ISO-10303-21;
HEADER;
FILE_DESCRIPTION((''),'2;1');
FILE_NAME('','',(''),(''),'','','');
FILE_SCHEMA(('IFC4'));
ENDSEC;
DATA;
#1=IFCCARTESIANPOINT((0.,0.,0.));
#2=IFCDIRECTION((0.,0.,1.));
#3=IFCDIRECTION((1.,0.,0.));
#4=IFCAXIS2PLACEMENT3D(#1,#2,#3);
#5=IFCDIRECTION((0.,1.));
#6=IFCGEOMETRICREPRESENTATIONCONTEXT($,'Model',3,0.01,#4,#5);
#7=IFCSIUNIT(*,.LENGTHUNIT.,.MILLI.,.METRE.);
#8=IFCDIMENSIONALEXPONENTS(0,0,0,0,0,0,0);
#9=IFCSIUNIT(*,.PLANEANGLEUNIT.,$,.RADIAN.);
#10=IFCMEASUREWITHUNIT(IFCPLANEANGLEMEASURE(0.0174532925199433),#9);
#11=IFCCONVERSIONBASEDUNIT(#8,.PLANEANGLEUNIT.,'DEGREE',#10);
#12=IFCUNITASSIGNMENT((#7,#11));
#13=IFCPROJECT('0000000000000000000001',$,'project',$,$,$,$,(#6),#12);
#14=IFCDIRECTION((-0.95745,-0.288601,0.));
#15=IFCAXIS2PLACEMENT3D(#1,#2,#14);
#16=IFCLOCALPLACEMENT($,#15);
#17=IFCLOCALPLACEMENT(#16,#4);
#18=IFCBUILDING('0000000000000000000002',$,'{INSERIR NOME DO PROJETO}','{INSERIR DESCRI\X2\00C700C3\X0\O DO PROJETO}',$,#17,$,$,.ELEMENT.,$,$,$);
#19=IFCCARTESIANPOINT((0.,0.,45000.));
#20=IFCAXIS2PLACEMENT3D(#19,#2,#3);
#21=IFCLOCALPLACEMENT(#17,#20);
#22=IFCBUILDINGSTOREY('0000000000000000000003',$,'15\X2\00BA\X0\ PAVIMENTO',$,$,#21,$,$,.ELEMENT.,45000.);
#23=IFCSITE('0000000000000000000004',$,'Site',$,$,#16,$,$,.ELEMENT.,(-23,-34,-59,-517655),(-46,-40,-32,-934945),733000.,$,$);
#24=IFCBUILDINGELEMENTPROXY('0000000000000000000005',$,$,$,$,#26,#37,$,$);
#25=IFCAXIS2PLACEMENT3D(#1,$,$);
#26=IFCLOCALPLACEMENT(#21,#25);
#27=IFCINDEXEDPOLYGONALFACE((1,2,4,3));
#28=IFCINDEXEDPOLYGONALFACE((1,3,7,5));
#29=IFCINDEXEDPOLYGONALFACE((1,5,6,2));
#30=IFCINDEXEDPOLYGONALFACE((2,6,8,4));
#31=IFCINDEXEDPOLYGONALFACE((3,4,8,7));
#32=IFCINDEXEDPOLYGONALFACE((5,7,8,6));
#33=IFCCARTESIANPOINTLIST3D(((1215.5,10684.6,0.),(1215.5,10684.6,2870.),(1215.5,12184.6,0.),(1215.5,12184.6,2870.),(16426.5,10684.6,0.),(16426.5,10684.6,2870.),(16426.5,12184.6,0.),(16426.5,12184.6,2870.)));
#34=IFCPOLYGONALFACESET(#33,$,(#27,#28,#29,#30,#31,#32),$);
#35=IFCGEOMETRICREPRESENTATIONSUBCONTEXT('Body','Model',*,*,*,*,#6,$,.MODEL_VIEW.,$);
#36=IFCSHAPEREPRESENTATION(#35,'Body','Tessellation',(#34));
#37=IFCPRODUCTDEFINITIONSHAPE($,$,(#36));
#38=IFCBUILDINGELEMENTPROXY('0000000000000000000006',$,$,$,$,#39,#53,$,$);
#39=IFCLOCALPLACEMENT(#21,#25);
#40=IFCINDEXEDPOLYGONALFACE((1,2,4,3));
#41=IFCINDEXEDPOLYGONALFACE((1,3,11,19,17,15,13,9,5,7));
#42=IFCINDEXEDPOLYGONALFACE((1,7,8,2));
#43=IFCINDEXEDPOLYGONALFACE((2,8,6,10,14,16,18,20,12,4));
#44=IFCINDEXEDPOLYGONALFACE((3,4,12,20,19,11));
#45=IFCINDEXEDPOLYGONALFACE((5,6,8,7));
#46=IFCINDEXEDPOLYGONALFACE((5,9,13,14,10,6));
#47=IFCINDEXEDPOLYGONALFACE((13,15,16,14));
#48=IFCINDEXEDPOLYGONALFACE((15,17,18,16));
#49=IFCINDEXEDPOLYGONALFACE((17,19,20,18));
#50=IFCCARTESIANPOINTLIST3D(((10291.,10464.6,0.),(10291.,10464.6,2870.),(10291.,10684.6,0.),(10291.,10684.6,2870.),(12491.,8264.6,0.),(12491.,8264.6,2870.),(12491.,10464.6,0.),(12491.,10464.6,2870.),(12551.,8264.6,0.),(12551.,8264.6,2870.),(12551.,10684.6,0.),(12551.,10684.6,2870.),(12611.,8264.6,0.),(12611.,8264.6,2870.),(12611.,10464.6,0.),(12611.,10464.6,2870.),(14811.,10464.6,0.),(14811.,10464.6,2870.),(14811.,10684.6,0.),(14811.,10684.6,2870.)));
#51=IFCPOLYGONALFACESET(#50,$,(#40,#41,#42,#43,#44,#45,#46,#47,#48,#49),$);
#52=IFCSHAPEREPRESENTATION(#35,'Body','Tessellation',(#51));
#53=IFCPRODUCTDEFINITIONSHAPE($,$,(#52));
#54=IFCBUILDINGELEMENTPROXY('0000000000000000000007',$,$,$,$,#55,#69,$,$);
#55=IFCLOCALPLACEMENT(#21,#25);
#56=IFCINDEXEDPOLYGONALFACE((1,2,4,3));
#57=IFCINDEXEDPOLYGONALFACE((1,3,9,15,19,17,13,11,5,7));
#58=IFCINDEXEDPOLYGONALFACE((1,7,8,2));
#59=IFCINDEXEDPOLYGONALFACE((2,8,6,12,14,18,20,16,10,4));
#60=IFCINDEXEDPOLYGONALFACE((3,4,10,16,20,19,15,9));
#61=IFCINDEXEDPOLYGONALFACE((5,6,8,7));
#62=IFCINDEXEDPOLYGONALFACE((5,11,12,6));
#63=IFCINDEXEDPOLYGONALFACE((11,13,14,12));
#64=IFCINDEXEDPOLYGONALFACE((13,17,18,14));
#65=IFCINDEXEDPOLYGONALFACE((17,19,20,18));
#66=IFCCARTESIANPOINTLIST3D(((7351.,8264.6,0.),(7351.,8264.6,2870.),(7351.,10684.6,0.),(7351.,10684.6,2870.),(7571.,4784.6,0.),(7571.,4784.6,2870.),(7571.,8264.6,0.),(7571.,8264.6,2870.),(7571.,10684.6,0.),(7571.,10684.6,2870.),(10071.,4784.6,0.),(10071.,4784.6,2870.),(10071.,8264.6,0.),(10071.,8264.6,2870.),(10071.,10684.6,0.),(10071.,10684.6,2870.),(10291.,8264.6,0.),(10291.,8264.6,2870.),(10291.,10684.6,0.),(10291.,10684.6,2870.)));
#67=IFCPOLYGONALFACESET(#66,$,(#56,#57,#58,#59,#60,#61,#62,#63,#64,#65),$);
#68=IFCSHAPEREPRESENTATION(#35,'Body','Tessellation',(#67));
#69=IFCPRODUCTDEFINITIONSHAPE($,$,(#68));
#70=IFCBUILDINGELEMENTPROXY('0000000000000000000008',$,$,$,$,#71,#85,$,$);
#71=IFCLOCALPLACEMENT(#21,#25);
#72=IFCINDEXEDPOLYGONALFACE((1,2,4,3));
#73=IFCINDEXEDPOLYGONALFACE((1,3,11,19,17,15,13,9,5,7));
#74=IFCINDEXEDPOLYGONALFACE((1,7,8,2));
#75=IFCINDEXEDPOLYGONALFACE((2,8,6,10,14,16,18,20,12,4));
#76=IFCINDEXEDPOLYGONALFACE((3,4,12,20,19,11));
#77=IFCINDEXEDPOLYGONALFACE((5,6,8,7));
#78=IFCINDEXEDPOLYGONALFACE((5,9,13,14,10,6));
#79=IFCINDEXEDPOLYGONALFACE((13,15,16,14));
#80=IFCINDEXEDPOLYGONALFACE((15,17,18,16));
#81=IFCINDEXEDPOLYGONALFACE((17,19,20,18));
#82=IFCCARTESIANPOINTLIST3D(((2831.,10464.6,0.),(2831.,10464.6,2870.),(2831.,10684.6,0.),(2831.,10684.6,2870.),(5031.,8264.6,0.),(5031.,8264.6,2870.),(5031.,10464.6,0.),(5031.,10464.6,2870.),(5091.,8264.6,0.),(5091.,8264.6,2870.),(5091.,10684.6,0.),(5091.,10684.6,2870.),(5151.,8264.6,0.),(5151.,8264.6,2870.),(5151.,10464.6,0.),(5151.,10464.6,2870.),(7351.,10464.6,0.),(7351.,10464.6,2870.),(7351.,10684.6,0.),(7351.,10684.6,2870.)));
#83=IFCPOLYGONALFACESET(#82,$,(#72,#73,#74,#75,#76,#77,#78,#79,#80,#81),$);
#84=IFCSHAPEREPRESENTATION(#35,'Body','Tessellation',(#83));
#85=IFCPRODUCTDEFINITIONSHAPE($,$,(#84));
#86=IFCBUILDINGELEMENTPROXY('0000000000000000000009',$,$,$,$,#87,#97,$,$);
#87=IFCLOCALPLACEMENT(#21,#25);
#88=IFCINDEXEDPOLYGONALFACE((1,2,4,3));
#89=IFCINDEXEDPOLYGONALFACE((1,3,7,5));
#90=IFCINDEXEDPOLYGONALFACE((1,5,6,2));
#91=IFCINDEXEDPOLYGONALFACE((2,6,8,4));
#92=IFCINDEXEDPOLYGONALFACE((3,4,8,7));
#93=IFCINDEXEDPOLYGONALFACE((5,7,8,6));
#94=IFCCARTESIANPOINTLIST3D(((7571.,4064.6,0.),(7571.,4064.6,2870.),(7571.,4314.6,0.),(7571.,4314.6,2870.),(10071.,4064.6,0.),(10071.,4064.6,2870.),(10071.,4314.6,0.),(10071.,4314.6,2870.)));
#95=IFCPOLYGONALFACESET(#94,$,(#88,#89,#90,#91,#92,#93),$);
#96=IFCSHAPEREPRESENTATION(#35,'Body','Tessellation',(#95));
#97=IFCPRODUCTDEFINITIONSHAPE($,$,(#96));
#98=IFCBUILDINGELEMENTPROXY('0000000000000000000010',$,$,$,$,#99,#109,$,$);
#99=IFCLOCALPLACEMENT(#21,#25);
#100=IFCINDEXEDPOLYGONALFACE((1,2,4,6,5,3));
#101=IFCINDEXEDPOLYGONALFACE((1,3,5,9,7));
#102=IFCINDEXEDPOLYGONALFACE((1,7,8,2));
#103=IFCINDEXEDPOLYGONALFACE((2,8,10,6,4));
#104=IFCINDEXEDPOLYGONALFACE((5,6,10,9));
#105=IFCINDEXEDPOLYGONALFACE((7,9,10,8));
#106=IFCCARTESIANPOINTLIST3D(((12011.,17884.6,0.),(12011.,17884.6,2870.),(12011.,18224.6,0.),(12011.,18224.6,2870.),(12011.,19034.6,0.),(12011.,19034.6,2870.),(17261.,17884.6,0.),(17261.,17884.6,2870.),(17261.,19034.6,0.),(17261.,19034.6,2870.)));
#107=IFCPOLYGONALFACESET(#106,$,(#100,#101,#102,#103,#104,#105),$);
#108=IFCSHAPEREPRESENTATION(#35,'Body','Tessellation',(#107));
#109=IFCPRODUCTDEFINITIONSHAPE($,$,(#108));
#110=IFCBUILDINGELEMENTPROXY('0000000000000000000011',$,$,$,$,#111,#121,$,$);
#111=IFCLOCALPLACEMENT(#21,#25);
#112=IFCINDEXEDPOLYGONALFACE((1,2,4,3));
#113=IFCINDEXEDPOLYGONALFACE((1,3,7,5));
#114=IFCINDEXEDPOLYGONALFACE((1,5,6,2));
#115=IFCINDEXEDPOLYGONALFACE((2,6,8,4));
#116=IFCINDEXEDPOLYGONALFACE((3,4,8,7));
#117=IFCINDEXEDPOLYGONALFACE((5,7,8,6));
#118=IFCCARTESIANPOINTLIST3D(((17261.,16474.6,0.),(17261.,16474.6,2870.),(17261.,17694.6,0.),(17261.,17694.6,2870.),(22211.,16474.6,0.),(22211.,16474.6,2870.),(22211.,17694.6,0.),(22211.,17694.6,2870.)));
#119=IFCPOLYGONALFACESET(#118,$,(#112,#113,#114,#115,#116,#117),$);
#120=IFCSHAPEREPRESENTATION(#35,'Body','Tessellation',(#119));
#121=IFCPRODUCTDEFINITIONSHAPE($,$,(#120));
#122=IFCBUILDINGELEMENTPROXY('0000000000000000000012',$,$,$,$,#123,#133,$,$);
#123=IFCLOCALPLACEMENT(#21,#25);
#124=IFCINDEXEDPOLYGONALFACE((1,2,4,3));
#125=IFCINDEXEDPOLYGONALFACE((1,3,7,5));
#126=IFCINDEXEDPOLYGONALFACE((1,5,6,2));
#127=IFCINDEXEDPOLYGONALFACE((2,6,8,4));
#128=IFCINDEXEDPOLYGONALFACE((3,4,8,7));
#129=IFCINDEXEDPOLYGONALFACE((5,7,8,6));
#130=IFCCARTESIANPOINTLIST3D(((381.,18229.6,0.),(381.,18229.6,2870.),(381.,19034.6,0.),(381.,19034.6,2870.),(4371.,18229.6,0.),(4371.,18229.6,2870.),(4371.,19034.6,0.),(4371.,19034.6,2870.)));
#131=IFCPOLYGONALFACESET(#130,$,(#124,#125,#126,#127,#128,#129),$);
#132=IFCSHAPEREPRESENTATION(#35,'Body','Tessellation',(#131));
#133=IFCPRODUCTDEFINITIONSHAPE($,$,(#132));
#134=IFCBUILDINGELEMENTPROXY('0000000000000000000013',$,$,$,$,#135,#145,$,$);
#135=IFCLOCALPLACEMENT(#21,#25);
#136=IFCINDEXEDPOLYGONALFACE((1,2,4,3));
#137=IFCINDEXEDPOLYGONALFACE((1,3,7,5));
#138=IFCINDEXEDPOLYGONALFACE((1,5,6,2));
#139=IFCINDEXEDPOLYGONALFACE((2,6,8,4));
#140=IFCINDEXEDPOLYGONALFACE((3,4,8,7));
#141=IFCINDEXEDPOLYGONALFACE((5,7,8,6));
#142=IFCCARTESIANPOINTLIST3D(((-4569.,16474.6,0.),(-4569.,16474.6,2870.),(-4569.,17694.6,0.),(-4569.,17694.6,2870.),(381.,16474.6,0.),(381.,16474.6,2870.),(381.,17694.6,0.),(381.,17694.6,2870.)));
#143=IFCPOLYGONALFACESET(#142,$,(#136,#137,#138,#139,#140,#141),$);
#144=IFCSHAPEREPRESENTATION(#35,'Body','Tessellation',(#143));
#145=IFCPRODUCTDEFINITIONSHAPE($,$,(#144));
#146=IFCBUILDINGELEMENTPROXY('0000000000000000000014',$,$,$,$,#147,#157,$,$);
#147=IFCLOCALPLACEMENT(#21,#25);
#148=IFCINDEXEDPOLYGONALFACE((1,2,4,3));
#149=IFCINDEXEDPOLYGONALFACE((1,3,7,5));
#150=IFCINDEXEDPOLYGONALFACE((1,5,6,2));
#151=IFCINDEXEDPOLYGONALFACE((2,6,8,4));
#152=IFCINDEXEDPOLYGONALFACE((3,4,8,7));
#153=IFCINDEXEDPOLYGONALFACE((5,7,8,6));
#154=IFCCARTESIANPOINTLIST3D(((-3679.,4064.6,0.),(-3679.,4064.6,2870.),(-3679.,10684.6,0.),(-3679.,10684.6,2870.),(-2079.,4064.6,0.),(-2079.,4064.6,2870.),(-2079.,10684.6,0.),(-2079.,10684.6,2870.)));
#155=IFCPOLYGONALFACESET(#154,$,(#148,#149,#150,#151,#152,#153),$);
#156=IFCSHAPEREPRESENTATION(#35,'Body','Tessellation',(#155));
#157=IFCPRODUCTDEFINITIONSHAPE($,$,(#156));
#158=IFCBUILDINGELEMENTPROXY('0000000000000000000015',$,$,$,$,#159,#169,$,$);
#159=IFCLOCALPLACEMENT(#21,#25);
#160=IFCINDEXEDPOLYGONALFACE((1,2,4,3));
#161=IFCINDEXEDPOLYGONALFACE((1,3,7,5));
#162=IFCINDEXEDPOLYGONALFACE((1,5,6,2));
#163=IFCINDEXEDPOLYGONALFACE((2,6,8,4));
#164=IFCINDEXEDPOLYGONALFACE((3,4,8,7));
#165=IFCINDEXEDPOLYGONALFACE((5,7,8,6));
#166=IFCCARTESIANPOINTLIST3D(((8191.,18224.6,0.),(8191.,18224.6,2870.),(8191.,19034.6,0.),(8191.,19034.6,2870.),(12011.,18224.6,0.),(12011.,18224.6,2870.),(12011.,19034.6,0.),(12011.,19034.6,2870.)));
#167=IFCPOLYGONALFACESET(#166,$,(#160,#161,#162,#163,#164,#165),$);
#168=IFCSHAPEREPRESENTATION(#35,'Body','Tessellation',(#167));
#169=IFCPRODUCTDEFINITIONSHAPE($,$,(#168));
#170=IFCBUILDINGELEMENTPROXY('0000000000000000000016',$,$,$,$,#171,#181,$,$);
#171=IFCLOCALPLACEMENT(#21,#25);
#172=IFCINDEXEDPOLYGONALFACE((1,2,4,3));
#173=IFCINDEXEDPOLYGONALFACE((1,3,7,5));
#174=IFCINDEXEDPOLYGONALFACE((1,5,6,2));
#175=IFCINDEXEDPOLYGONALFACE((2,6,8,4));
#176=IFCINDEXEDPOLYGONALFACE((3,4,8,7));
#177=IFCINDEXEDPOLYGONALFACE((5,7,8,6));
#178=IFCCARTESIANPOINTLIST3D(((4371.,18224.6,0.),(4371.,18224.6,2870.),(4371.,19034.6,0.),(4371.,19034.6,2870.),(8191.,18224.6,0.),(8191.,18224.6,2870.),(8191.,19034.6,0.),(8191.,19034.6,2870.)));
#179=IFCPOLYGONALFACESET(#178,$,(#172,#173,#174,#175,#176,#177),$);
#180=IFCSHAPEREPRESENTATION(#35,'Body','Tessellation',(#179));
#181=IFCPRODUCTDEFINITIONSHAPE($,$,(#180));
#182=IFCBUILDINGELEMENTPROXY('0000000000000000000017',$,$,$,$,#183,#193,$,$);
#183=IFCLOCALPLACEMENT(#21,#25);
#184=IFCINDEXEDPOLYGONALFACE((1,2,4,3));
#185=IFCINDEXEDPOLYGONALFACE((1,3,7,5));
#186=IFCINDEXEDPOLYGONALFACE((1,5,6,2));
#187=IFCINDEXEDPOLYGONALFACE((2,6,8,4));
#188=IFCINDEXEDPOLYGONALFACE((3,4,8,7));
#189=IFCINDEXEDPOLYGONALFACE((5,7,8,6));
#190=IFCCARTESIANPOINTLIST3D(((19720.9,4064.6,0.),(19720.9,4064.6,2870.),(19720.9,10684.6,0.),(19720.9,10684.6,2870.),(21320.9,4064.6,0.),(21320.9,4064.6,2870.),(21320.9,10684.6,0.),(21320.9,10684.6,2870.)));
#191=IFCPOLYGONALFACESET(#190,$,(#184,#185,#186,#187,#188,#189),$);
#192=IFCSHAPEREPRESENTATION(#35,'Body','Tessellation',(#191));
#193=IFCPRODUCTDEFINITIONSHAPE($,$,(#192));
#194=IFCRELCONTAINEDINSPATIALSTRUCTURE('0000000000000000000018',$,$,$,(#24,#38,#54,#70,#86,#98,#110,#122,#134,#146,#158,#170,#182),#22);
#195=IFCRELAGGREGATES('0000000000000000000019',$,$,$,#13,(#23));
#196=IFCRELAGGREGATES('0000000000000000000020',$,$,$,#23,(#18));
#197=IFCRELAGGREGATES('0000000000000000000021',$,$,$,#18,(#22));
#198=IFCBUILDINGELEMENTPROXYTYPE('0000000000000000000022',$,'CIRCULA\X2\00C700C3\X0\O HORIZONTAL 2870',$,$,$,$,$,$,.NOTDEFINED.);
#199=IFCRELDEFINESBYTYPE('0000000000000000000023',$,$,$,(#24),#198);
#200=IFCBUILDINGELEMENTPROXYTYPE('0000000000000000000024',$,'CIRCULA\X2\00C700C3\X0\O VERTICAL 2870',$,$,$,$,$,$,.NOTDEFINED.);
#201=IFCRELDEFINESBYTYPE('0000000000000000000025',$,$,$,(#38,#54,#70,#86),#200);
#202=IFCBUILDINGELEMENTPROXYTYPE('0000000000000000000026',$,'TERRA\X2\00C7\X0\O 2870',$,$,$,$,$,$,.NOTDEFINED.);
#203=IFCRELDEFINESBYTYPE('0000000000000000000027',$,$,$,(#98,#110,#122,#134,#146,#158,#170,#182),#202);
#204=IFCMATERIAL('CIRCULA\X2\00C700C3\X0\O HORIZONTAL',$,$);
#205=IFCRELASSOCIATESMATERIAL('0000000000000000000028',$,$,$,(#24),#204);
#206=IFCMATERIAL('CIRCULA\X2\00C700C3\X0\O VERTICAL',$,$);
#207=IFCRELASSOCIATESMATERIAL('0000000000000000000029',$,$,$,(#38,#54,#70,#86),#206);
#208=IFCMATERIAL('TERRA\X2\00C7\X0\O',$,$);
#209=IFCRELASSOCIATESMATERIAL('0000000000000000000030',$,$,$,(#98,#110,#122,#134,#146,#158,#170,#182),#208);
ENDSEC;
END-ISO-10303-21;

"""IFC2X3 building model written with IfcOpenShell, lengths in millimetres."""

from ifc_helpers import new_model, entity, si_unit, converted_unit, direction, frame, origin_with_axes, place, context, subcontext, project, spatial, polyline, outline, extrude, material, type_object, element, save


model = new_model("IFC2X3")

# Units and contexts
model_context = context("Model", 3, precision=0.01, world=origin_with_axes(), true_north=direction((0.0, 1.0)))
body_context = subcontext(model_context, "Body", "Model", "MODEL_VIEW")
ifc_project = project(units=[si_unit("LENGTHUNIT", "METRE", prefix="MILLI"), converted_unit("PLANEANGLEUNIT", "DEGREE", entity("IfcPlaneAngleMeasure", 0.0174532925199433), si_unit("PLANEANGLEUNIT", "RADIAN"), dimensions=[0, 0, 0, 0, 0, 0, 0])], contexts=[model_context])

# Site, building, storey
site_placement = place(None, frame((0.0, 0.0, 0.0), z_axis=(0.0, 0.0, 1.0), x_axis=(-0.95745, -0.288601, 0.0)))
site = spatial("IfcSite", under=ifc_project, at=site_placement, Name="Site", CompositionType="ELEMENT", RefLatitude=(-23, -34, -59, -517655), RefLongitude=(-46, -40, -32, -934945), RefElevation=733000.0)
building_placement = place(site_placement, origin_with_axes())
building = spatial("IfcBuilding", under=site, at=building_placement, Name="{INSERIR NOME DO PROJETO}", Description="{INSERIR DESCRIÇÃO DO PROJETO}", CompositionType="ELEMENT")
storey_placement = place(building_placement, frame((0.0, 0.0, 45000.0), z_axis=(0.0, 0.0, 1.0), x_axis=(1.0, 0.0, 0.0)))
storey = spatial("IfcBuildingStorey", under=building, at=storey_placement, Name="15º PAVIMENTO", CompositionType="ELEMENT", Elevation=45000.0)

# Building element proxies
ifc_material_1 = material(Name="CIRCULAÇÃO HORIZONTAL")
building_element_proxy_type_1 = type_object("IfcBuildingElementProxyType", Name="CIRCULAÇÃO HORIZONTAL 2870", PredefinedType="NOTDEFINED")
proxy_1_placement = place(storey_placement, frame((1215.5, 10684.6, 0.0), z_axis=(0.0, 0.0, 1.0), x_axis=(1.0, 0.0, 0.0)))
element("IfcBuildingElementProxy", 1, at=proxy_1_placement, inside=storey, type_object=building_element_proxy_type_1, material=ifc_material_1, context=body_context, shape_type="SweptSolid", body=[
    extrude(outline(polyline([(0.0, 0.0), (15211.0, 0.0), (15211.0, 1500.0), (0.0, 1500.0), (0.0, 0.0)])), origin_with_axes(), (0.0, 0.0, 1.0), 2870.0),
])
ifc_material_2 = material(Name="CIRCULAÇÃO VERTICAL")
building_element_proxy_type_2 = type_object("IfcBuildingElementProxyType", Name="CIRCULAÇÃO VERTICAL 2870", PredefinedType="NOTDEFINED")
proxy_2_placement = place(storey_placement, frame((10291.0, 10684.6, 0.0), z_axis=(0.0, 0.0, 1.0), x_axis=(1.0, 0.0, 0.0)))
element("IfcBuildingElementProxy", 2, at=proxy_2_placement, inside=storey, type_object=building_element_proxy_type_2, material=ifc_material_2, context=body_context, shape_type="SweptSolid", body=[
    extrude(outline(polyline([(0.0, 0.0), (0.0, -220.0), (2200.0, -220.0), (2200.0, -2420.0), (2260.0, -2420.0), (2320.0, -2420.0), (2320.0, -220.0), (4520.0, -220.0), (4520.0, 0.0), (2260.0, 0.0), (0.0, 0.0)])), origin_with_axes(), (0.0, 0.0, 1.0), 2870.0),
])
proxy_3_placement = place(storey_placement, frame((7351.0, 10684.6, 0.0), z_axis=(0.0, 0.0, 1.0), x_axis=(1.0, 0.0, 0.0)))
element("IfcBuildingElementProxy", 3, at=proxy_3_placement, inside=storey, type_object=building_element_proxy_type_2, material=ifc_material_2, context=body_context, shape_type="SweptSolid", body=[
    extrude(outline(polyline([(0.0, 0.0), (0.0, -2420.0), (220.0, -2420.0), (220.0, -5900.0), (2720.0, -5900.0), (2720.0, -2420.0), (2940.0, -2420.0), (2940.0, 0.0), (2720.0, 0.0), (220.0, 0.0), (0.0, 0.0)])), origin_with_axes(), (0.0, 0.0, 1.0), 2870.0),
])
proxy_4_placement = place(storey_placement, frame((5091.0, 10684.6, 0.0), z_axis=(0.0, 0.0, 1.0), x_axis=(1.0, 0.0, 0.0)))
element("IfcBuildingElementProxy", 4, at=proxy_4_placement, inside=storey, type_object=building_element_proxy_type_2, material=ifc_material_2, context=body_context, shape_type="SweptSolid", body=[
    extrude(outline(polyline([(0.0, 0.0), (-2260.0, 0.0), (-2260.0, -220.0), (-60.0, -220.0), (-60.0, -2420.0), (0.0, -2420.0), (60.0, -2420.0), (60.0, -220.0), (2260.0, -220.0), (2260.0, 0.0), (0.0, 0.0)])), origin_with_axes(), (0.0, 0.0, 1.0), 2870.0),
])
proxy_5_placement = place(storey_placement, frame((7571.0, 4064.6, 0.0), z_axis=(0.0, 0.0, 1.0), x_axis=(1.0, 0.0, 0.0)))
element("IfcBuildingElementProxy", 5, at=proxy_5_placement, inside=storey, type_object=building_element_proxy_type_2, material=ifc_material_2, context=body_context, shape_type="SweptSolid", body=[
    extrude(outline(polyline([(0.0, 0.0), (2500.0, 0.0), (2500.0, 250.0), (0.0, 250.0), (0.0, 0.0)])), origin_with_axes(), (0.0, 0.0, 1.0), 2870.0),
])
ifc_material_3 = material(Name="TERRAÇO")
building_element_proxy_type_3 = type_object("IfcBuildingElementProxyType", Name="TERRAÇO 2870", PredefinedType="NOTDEFINED")
proxy_6_placement = place(storey_placement, frame((12011.0, 19034.6, 0.0), z_axis=(0.0, 0.0, 1.0), x_axis=(1.0, 0.0, 0.0)))
element("IfcBuildingElementProxy", 6, at=proxy_6_placement, inside=storey, type_object=building_element_proxy_type_3, material=ifc_material_3, context=body_context, shape_type="SweptSolid", body=[
    extrude(outline(polyline([(0.0, 0.0), (0.0, -810.0), (0.0, -1150.0), (5250.0, -1150.0), (5250.0, 0.0), (0.0, 0.0)])), origin_with_axes(), (0.0, 0.0, 1.0), 2870.0),
])
proxy_7_placement = place(storey_placement, frame((17261.0, 16474.6, 0.0), z_axis=(0.0, 0.0, 1.0), x_axis=(1.0, 0.0, 0.0)))
element("IfcBuildingElementProxy", 7, at=proxy_7_placement, inside=storey, type_object=building_element_proxy_type_3, material=ifc_material_3, context=body_context, shape_type="SweptSolid", body=[
    extrude(outline(polyline([(0.0, 0.0), (4950.0, 0.0), (4950.0, 1220.0), (0.0, 1220.0), (0.0, 0.0)])), origin_with_axes(), (0.0, 0.0, 1.0), 2870.0),
])
proxy_8_placement = place(storey_placement, frame((381.0, 19034.6, 0.0), z_axis=(0.0, 0.0, 1.0), x_axis=(1.0, 0.0, 0.0)))
element("IfcBuildingElementProxy", 8, at=proxy_8_placement, inside=storey, type_object=building_element_proxy_type_3, material=ifc_material_3, context=body_context, shape_type="SweptSolid", body=[
    extrude(outline(polyline([(0.0, 0.0), (0.0, -805.0), (3990.0, -805.0), (3990.0, 0.0), (0.0, 0.0)])), origin_with_axes(), (0.0, 0.0, 1.0), 2870.0),
])
proxy_9_placement = place(storey_placement, frame((381.0, 17694.6, 0.0), z_axis=(0.0, 0.0, 1.0), x_axis=(1.0, 0.0, 0.0)))
element("IfcBuildingElementProxy", 9, at=proxy_9_placement, inside=storey, type_object=building_element_proxy_type_3, material=ifc_material_3, context=body_context, shape_type="SweptSolid", body=[
    extrude(outline(polyline([(0.0, 0.0), (-4950.0, 0.0), (-4950.0, -1220.0), (0.0, -1220.0), (0.0, 0.0)])), origin_with_axes(), (0.0, 0.0, 1.0), 2870.0),
])
proxy_10_placement = place(storey_placement, frame((-3679.0, 4064.6, 0.0), z_axis=(0.0, 0.0, 1.0), x_axis=(1.0, 0.0, 0.0)))
element("IfcBuildingElementProxy", 10, at=proxy_10_placement, inside=storey, type_object=building_element_proxy_type_3, material=ifc_material_3, context=body_context, shape_type="SweptSolid", body=[
    extrude(outline(polyline([(0.0, 0.0), (1600.0, 0.0), (1600.0, 6620.0), (0.0, 6620.0), (0.0, 0.0)])), origin_with_axes(), (0.0, 0.0, 1.0), 2870.0),
])
for number, where, z_axis, x_axis in (
    (11, (8191.0, 18224.6, 0.0), (0.0, 0.0, 1.0), (1.0, 0.0, 0.0)),
    (12, (4371.0, 18224.6, 0.0), (0.0, 0.0, 1.0), (1.0, 0.0, 0.0)),
):
    element("IfcBuildingElementProxy", number, at=place(storey_placement, frame(where, z_axis=z_axis, x_axis=x_axis)), inside=storey, type_object=building_element_proxy_type_3, material=ifc_material_3, context=body_context, shape_type="SweptSolid", body=[
        extrude(outline(polyline([(0.0, 0.0), (3820.0, 0.0), (3820.0, 810.0), (0.0, 810.0), (0.0, 0.0)])), origin_with_axes(), (0.0, 0.0, 1.0), 2870.0),
    ])
proxy_11_placement = place(storey_placement, frame((21320.9, 4064.6, 0.0), z_axis=(0.0, 0.0, 1.0), x_axis=(1.0, 0.0, 0.0)))
element("IfcBuildingElementProxy", 13, at=proxy_11_placement, inside=storey, type_object=building_element_proxy_type_3, material=ifc_material_3, context=body_context, shape_type="SweptSolid", body=[
    extrude(outline(polyline([(0.0, 0.0), (0.0, 6620.0), (-1600.0, 6620.0), (-1600.0, 0.0), (0.0, 0.0)])), origin_with_axes(), (0.0, 0.0, 1.0), 2870.0),
])

save(model, "model.ifc")
